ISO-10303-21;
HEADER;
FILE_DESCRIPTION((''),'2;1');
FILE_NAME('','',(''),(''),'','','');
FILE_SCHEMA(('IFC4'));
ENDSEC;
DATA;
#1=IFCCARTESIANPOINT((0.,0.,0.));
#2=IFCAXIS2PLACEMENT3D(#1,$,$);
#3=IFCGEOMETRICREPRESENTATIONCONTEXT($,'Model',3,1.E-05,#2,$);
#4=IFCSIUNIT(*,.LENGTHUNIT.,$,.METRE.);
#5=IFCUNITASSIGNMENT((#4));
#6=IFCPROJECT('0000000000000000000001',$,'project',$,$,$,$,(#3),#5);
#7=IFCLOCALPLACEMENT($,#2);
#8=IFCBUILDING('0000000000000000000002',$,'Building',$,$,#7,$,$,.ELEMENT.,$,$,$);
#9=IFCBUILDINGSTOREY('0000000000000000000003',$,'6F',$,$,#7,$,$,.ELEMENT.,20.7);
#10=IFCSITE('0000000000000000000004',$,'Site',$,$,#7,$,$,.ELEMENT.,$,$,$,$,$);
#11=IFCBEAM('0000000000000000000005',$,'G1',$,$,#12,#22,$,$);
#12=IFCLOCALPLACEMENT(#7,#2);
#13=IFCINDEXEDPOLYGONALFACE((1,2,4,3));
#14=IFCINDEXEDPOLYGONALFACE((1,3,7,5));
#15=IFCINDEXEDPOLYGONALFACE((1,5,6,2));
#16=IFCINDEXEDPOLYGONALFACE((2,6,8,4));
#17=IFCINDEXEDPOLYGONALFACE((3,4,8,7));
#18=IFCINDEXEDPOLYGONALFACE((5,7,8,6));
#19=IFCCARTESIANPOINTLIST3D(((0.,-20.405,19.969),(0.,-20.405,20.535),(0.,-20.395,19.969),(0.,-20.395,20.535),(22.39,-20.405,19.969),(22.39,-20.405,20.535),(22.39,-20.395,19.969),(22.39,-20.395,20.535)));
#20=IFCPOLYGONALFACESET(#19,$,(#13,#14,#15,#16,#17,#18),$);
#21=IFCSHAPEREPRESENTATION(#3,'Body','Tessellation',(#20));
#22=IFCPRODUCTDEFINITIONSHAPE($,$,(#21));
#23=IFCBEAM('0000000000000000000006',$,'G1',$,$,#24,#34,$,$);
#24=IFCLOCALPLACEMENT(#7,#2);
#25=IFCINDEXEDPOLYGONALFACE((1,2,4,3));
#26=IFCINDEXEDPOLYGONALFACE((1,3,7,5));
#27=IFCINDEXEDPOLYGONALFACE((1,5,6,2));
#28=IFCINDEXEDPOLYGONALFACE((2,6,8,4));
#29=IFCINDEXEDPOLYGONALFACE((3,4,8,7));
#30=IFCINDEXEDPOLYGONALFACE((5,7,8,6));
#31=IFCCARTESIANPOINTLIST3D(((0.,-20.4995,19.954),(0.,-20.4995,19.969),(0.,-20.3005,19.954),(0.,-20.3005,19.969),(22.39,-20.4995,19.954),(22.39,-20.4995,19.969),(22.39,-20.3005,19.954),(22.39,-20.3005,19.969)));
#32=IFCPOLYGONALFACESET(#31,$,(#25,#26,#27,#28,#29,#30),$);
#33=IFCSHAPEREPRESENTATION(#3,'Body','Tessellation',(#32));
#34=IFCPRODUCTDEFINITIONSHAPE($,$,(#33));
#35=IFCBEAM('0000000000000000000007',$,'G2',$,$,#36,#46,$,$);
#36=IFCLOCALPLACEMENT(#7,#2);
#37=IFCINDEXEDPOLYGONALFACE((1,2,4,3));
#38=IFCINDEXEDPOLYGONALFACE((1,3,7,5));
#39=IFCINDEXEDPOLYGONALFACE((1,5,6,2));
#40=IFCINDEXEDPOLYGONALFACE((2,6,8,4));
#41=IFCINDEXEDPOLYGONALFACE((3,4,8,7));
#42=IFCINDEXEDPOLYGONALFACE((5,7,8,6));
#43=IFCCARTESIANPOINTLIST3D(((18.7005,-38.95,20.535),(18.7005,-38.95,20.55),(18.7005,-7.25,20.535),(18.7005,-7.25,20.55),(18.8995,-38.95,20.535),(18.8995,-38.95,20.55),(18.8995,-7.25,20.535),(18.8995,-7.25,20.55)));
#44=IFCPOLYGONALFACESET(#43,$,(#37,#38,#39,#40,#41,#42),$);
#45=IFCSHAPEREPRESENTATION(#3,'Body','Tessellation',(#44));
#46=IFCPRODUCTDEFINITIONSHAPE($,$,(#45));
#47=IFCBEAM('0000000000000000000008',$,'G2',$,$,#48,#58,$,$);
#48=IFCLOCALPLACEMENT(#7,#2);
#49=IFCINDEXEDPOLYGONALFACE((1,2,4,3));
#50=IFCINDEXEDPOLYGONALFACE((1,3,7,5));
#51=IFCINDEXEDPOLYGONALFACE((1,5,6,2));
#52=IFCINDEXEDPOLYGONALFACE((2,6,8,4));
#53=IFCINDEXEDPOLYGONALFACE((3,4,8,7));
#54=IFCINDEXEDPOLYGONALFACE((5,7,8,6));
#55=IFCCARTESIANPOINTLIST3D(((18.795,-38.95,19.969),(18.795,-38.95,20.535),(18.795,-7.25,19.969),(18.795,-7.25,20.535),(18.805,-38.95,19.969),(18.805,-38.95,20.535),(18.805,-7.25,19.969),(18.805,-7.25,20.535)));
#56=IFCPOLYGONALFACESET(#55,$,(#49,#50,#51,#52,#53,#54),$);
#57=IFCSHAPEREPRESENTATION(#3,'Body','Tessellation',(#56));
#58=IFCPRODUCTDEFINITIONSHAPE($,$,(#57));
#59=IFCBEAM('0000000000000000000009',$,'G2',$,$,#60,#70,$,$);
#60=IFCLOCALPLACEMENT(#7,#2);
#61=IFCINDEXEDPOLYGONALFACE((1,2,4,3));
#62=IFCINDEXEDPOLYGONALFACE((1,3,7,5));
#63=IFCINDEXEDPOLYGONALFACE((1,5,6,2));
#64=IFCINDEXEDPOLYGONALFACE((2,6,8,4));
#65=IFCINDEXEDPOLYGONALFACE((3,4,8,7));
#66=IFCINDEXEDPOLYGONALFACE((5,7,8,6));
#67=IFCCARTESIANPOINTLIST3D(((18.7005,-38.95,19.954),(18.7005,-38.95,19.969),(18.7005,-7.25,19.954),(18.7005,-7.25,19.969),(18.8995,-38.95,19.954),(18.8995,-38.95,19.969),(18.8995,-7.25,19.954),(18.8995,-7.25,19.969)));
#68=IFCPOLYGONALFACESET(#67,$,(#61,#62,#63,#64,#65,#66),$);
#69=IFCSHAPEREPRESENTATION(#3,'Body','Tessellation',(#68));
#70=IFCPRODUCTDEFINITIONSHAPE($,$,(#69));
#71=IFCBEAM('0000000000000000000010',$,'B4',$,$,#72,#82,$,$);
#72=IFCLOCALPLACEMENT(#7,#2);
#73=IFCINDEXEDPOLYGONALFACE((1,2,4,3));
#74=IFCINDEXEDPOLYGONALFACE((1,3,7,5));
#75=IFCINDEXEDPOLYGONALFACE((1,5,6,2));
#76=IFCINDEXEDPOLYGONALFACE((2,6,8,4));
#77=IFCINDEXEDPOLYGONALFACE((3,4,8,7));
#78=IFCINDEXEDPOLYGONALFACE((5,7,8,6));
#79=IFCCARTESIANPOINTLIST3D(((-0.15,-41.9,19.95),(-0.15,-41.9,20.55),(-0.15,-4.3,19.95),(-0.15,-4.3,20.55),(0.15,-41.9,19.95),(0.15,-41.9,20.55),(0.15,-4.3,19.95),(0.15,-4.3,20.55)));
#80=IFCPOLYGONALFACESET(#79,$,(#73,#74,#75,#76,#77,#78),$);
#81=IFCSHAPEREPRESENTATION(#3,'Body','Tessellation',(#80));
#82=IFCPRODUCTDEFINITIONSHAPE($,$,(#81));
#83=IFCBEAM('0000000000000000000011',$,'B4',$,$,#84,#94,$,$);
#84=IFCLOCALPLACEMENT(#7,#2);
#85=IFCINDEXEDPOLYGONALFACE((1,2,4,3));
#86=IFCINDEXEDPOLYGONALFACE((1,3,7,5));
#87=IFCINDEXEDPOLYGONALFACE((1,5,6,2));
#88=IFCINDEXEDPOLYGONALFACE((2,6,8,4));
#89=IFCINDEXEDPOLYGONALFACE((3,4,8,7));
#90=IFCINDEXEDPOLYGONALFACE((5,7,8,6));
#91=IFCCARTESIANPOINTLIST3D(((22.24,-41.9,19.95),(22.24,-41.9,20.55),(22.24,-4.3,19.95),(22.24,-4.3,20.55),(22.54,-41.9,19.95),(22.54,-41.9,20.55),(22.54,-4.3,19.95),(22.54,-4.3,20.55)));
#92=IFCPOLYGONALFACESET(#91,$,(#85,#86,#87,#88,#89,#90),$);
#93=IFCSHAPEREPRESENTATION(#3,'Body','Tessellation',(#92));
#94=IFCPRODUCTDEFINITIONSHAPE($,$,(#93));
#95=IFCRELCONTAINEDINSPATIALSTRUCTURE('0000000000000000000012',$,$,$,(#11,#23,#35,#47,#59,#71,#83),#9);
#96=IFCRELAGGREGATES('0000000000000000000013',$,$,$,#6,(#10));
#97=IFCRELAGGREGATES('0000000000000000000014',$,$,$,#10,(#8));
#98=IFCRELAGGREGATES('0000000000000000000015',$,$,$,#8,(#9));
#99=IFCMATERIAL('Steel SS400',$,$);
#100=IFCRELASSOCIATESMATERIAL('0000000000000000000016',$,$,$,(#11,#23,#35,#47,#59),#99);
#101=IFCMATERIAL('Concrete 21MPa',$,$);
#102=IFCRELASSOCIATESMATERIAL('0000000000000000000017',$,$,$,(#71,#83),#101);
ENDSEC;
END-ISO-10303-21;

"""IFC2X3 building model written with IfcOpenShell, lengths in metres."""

from ifc_helpers import new_model, si_unit, frame, origin, origin_2d, place, context, project, spatial, rectangle, extrude, material, element, save


model = new_model("IFC2X3")

# Units and contexts
model_context = context("Model", 3, precision=1e-05, world=origin())
ifc_project = project(units=[si_unit("LENGTHUNIT", "METRE")], contexts=[model_context])

# Site, building, storey
placement = place(None, origin())
site = spatial("IfcSite", under=ifc_project, at=placement, Name="Site", CompositionType="ELEMENT")
building = spatial("IfcBuilding", under=site, at=placement, Name="Building", CompositionType="ELEMENT")
storey = spatial("IfcBuildingStorey", under=building, at=placement, Name="6F", CompositionType="ELEMENT", Elevation=20.7)

# Shared definitions
ifc_material_1 = material(Name="Concrete 21MPa")
ifc_material_2 = material(Name="Steel SS400")

# Beams
beam_1_placement = place(None, frame((11.195, -20.4, 19.969)))
element("IfcBeam", 1, at=beam_1_placement, inside=storey, material=ifc_material_2, Name="G1", context=model_context, shape_type="SweptSolid", body=[
    extrude(rectangle(XDim=22.39, YDim=0.01, at=origin_2d()), origin(), (0.0, 0.0, 1.0), 0.566),
])
beam_2_placement = place(None, frame((11.195, -20.4, 19.954)))
element("IfcBeam", 2, at=beam_2_placement, inside=storey, material=ifc_material_2, Name="G1", context=model_context, shape_type="SweptSolid", body=[
    extrude(rectangle(XDim=22.39, YDim=0.199, at=origin_2d()), origin(), (0.0, 0.0, 1.0), 0.015),
])
beam_3_placement = place(None, frame((18.8, -23.1, 20.535)))
element("IfcBeam", 3, at=beam_3_placement, inside=storey, material=ifc_material_2, Name="G2", context=model_context, shape_type="SweptSolid", body=[
    extrude(rectangle(XDim=0.199, YDim=31.7, at=origin_2d()), origin(), (0.0, 0.0, 1.0), 0.015),
])
beam_4_placement = place(None, frame((18.8, -23.1, 19.969)))
element("IfcBeam", 4, at=beam_4_placement, inside=storey, material=ifc_material_2, Name="G2", context=model_context, shape_type="SweptSolid", body=[
    extrude(rectangle(XDim=0.01, YDim=31.7, at=origin_2d()), origin(), (0.0, 0.0, 1.0), 0.566),
])
beam_5_placement = place(None, frame((18.8, -23.1, 19.954)))
element("IfcBeam", 5, at=beam_5_placement, inside=storey, material=ifc_material_2, Name="G2", context=model_context, shape_type="SweptSolid", body=[
    extrude(rectangle(XDim=0.199, YDim=31.7, at=origin_2d()), origin(), (0.0, 0.0, 1.0), 0.015),
])
for number, where, name in (
    (6, (0.0, -23.1, 19.95), "B4"),
    (7, (22.39, -23.1, 19.95), "B4"),
):
    element("IfcBeam", number, at=place(None, frame(where)), inside=storey, material=ifc_material_1, Name=name, context=model_context, shape_type="SweptSolid", body=[
        extrude(rectangle(XDim=0.3, YDim=37.6, at=origin_2d()), origin(), (0.0, 0.0, 1.0), 0.6),
    ])

save(model, "model.ifc")
